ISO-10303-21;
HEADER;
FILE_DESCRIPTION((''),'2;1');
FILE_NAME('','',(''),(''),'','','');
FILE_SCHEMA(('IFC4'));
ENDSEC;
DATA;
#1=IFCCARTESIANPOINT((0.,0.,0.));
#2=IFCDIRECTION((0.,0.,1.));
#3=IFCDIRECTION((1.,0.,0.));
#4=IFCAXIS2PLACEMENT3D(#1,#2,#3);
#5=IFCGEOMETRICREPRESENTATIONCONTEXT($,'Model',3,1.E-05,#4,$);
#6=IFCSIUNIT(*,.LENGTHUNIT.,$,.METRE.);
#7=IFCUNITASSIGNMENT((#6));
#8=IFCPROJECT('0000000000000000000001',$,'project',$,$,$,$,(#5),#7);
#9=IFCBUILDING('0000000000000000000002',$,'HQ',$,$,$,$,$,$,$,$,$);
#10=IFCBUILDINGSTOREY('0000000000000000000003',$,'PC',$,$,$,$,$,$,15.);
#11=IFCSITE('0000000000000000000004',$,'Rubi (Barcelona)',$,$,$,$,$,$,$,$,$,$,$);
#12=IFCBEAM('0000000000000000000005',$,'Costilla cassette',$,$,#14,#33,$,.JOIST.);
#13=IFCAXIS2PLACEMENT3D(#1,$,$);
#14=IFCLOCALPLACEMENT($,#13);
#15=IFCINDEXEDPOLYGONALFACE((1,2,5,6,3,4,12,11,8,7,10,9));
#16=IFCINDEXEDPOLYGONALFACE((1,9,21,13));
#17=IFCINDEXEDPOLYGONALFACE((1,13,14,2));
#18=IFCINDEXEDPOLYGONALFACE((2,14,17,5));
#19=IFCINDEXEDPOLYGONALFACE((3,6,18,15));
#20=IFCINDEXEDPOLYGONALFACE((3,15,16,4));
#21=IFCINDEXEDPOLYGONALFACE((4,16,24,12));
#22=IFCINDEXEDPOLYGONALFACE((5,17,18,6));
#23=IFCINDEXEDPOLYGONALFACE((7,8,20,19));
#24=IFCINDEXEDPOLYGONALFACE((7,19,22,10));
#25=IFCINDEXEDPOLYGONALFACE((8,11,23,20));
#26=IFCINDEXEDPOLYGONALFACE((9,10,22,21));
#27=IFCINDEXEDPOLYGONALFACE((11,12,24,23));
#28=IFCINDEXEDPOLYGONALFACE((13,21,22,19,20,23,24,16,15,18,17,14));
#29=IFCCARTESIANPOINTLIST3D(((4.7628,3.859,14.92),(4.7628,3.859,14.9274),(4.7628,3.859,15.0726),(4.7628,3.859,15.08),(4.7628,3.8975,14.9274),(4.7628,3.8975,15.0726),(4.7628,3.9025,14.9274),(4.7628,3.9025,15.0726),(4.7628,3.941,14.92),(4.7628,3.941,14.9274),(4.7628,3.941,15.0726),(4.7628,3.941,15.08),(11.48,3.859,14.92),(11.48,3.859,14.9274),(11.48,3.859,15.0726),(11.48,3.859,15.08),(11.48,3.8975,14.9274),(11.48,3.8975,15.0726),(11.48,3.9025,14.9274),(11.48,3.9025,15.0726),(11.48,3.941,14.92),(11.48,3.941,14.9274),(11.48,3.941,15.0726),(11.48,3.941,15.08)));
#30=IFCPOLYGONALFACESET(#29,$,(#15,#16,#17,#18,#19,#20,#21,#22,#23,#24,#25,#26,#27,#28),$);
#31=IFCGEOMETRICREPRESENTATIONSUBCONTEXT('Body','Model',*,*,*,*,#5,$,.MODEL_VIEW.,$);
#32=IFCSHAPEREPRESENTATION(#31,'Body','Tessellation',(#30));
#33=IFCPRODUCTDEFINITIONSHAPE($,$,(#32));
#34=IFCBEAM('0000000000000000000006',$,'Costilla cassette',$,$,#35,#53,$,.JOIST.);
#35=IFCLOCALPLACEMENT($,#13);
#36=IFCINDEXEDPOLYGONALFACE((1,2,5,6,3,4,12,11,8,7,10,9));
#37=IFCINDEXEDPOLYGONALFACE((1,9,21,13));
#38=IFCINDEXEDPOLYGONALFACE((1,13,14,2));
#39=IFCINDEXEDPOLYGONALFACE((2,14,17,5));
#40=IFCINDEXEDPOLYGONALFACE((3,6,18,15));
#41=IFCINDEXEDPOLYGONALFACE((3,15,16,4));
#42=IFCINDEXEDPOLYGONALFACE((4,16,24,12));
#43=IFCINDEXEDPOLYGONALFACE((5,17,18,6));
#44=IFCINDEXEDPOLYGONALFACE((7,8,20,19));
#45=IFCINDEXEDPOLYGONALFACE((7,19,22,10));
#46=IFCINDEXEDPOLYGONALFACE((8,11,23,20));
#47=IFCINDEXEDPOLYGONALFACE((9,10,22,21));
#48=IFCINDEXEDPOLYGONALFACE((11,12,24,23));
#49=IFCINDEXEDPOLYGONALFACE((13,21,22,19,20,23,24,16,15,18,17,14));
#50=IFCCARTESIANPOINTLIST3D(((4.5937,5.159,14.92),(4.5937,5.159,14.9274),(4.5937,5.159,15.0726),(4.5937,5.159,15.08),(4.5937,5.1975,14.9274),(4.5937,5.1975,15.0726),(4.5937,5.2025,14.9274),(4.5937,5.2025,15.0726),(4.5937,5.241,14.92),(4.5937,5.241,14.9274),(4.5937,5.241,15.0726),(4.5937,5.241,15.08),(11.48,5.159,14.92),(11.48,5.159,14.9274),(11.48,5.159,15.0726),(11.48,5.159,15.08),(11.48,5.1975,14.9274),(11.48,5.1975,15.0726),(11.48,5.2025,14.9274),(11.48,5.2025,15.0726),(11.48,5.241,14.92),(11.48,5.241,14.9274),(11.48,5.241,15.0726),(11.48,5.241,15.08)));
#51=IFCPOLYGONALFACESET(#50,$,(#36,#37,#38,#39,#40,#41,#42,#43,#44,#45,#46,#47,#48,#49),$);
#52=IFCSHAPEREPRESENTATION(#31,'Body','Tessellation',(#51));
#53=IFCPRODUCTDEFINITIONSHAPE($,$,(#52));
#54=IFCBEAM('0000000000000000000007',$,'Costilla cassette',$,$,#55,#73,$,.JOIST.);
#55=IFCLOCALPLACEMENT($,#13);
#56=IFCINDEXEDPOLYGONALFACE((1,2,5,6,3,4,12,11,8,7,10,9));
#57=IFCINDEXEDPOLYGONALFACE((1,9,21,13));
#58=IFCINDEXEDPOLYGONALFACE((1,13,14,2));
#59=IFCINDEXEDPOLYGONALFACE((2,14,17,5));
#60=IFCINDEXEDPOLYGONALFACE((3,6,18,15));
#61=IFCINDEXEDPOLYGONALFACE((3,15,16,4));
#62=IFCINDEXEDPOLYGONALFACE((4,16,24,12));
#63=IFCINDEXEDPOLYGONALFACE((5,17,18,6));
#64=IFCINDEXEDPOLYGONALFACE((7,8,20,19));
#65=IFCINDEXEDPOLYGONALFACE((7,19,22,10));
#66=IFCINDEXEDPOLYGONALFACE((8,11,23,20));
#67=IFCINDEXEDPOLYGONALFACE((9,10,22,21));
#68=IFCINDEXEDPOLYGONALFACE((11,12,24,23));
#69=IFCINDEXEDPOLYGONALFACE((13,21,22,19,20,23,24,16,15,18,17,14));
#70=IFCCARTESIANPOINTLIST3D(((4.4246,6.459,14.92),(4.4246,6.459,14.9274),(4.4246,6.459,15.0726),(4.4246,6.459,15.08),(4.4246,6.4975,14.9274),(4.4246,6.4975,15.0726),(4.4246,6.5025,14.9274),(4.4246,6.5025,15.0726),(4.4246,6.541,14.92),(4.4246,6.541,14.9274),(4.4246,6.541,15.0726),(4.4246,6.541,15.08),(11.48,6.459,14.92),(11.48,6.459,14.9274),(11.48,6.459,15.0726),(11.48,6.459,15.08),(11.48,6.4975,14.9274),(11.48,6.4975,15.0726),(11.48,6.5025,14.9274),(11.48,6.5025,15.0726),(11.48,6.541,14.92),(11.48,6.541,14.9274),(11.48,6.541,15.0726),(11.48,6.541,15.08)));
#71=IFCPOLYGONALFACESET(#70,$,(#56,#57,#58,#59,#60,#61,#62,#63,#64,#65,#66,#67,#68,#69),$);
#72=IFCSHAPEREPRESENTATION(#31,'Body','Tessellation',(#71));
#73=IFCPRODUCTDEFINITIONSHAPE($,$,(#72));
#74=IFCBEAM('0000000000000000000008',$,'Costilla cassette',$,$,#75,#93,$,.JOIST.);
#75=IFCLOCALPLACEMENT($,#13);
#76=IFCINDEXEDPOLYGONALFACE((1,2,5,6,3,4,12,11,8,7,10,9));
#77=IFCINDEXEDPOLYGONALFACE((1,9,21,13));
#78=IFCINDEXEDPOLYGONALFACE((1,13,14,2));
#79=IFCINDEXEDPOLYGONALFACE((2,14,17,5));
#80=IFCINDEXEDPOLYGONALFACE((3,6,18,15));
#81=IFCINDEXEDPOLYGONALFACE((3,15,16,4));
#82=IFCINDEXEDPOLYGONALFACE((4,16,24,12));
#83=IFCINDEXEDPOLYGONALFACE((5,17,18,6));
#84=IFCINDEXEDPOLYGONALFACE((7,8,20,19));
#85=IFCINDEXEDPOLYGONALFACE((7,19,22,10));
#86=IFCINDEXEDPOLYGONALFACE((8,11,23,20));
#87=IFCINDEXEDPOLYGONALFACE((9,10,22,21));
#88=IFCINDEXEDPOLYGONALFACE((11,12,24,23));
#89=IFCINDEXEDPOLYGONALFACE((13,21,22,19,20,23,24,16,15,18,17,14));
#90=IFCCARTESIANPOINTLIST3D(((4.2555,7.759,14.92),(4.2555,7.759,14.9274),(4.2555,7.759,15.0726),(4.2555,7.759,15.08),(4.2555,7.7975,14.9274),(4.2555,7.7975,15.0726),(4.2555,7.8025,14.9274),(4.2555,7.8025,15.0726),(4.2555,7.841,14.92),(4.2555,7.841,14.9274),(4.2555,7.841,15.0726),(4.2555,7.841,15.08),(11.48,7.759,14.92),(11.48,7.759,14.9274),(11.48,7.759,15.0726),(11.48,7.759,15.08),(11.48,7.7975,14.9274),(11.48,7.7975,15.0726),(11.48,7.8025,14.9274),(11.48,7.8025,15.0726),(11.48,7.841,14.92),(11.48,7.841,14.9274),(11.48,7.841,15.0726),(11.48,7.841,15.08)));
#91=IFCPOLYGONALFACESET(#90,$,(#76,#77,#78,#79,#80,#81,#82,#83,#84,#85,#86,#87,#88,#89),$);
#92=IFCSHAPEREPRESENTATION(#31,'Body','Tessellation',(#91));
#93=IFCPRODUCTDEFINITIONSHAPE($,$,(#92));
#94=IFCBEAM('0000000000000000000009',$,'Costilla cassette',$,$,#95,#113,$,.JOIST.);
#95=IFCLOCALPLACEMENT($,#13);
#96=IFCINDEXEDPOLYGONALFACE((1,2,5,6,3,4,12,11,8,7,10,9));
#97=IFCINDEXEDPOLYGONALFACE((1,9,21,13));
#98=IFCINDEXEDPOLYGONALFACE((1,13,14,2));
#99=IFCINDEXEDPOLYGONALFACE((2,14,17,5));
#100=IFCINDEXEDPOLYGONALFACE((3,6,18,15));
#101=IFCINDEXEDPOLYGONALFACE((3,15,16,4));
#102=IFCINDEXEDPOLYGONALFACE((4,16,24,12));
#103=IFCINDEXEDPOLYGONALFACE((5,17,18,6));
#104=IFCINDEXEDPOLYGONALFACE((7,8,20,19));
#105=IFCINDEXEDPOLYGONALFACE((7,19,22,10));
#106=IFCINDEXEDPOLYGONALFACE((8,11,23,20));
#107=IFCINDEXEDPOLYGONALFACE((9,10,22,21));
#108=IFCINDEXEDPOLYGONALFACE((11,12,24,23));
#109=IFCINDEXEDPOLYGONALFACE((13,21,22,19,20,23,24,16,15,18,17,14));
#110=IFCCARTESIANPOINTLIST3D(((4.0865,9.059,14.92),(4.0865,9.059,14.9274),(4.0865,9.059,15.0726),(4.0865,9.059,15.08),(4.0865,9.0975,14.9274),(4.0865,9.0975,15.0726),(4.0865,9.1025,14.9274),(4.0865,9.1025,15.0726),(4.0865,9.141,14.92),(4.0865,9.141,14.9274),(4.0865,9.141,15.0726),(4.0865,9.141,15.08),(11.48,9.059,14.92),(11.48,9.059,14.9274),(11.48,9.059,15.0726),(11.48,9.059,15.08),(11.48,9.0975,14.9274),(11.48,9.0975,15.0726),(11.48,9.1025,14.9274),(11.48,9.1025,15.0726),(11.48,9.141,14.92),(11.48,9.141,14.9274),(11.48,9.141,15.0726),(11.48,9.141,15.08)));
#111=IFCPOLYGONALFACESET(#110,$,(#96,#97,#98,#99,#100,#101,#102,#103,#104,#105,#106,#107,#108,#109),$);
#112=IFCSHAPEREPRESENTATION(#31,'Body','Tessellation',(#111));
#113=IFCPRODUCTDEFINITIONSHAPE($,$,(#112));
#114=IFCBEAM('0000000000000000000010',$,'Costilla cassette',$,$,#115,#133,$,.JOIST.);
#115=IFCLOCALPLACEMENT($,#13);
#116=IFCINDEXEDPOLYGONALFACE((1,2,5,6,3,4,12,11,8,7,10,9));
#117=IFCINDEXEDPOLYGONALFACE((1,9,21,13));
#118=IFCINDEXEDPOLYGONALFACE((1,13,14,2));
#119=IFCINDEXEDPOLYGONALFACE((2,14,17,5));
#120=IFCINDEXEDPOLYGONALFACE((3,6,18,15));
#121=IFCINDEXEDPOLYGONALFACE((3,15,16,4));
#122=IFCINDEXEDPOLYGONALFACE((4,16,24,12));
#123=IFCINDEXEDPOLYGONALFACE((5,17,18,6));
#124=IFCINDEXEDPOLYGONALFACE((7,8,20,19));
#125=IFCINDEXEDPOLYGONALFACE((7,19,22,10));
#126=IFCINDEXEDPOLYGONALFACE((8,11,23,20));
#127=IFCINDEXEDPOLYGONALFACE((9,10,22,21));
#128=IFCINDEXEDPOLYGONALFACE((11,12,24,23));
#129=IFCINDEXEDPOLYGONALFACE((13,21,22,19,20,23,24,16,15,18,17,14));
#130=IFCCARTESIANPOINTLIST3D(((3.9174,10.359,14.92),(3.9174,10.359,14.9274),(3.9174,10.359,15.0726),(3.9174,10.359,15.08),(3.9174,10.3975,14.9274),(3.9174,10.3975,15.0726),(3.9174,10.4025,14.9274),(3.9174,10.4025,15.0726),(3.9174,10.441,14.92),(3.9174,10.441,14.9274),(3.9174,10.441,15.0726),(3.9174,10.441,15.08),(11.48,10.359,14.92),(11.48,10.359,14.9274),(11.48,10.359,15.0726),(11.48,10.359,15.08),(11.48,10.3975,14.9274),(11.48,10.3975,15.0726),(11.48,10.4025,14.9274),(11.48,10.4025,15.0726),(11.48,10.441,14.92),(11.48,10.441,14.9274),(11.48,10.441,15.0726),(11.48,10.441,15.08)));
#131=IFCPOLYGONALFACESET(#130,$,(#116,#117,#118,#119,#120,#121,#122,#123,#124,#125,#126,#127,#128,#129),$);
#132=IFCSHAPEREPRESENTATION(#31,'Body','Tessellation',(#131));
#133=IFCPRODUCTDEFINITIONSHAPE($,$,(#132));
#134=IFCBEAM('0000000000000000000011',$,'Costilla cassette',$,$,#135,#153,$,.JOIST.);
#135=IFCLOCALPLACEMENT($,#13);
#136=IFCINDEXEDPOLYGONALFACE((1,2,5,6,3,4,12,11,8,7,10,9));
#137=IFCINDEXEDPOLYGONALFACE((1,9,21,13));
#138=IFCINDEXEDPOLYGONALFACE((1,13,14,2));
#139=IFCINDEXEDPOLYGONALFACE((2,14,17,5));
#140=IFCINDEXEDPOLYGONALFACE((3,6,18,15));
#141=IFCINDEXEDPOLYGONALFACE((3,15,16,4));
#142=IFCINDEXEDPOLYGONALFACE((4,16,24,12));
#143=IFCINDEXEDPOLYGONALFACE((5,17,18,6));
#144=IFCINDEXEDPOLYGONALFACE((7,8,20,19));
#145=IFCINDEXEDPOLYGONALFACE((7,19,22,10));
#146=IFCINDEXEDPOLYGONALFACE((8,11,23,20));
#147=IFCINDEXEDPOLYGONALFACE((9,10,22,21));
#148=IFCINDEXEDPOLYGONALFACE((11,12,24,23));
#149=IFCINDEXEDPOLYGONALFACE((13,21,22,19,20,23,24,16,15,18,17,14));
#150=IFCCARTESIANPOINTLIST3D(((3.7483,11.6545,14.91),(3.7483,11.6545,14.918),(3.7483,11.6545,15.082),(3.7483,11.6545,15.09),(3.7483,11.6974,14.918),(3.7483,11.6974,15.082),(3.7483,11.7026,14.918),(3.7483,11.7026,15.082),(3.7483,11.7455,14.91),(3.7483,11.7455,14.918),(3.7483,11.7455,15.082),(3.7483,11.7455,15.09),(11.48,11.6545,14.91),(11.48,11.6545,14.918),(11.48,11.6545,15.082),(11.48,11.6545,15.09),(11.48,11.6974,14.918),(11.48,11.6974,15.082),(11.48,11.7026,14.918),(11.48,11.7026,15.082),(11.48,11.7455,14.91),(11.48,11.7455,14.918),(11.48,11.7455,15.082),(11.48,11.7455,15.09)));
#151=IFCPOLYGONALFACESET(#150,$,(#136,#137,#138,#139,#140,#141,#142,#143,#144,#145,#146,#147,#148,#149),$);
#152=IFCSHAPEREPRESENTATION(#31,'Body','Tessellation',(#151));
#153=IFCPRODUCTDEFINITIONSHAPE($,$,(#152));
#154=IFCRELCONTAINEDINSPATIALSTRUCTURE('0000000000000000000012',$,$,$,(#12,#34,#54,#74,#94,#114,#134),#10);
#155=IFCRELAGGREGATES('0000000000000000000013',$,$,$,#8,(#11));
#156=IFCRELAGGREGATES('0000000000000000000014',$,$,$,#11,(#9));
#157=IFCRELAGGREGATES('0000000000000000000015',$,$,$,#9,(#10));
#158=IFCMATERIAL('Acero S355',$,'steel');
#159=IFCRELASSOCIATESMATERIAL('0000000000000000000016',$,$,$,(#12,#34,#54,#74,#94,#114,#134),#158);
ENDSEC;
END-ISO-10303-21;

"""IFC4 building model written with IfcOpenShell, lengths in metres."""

from ifc_helpers import new_model, si_unit, frame, origin_with_axes, place, context, subcontext, project, spatial, i_section, extrude, material, element, save


model = new_model("IFC4")

# Units and contexts
model_context = context("Model", 3, precision=1e-05, world=origin_with_axes())
body_context = subcontext(model_context, "Body", "Model", "MODEL_VIEW")
ifc_project = project(units=[si_unit("LENGTHUNIT", "METRE")], contexts=[model_context])

# Site, building, storey
site = spatial("IfcSite", under=ifc_project, Name="Rubi (Barcelona)")
building = spatial("IfcBuilding", under=site, Name="HQ")
storey = spatial("IfcBuildingStorey", under=building, Name="PC", Elevation=15.0)

# Shared definitions
ifc_material = material(Name="Acero S355", Category="steel")

# Beams
beam_1_placement = place(None, origin_with_axes())
element("IfcBeam", 1, at=beam_1_placement, inside=storey, material=ifc_material, Name="Costilla cassette", PredefinedType="JOIST", context=body_context, shape_type="SweptSolid", body=[
    extrude(i_section(OverallWidth=0.082, OverallDepth=0.16, WebThickness=0.005, FlangeThickness=0.0074), frame((4.7628, 3.9, 15.0), z_axis=(1.0, 0.0, 0.0), x_axis=(0.0, 1.0, 0.0)), (0.0, 0.0, 1.0), 6.7172),
])
beam_2_placement = place(None, origin_with_axes())
element("IfcBeam", 2, at=beam_2_placement, inside=storey, material=ifc_material, Name="Costilla cassette", PredefinedType="JOIST", context=body_context, shape_type="SweptSolid", body=[
    extrude(i_section(OverallWidth=0.082, OverallDepth=0.16, WebThickness=0.005, FlangeThickness=0.0074), frame((4.5937, 5.2, 15.0), z_axis=(1.0, 0.0, 0.0), x_axis=(0.0, 1.0, 0.0)), (0.0, 0.0, 1.0), 6.8863),
])
beam_3_placement = place(None, origin_with_axes())
element("IfcBeam", 3, at=beam_3_placement, inside=storey, material=ifc_material, Name="Costilla cassette", PredefinedType="JOIST", context=body_context, shape_type="SweptSolid", body=[
    extrude(i_section(OverallWidth=0.082, OverallDepth=0.16, WebThickness=0.005, FlangeThickness=0.0074), frame((4.4246, 6.5, 15.0), z_axis=(1.0, 0.0, 0.0), x_axis=(0.0, 1.0, 0.0)), (0.0, 0.0, 1.0), 7.0554),
])
beam_4_placement = place(None, origin_with_axes())
element("IfcBeam", 4, at=beam_4_placement, inside=storey, material=ifc_material, Name="Costilla cassette", PredefinedType="JOIST", context=body_context, shape_type="SweptSolid", body=[
    extrude(i_section(OverallWidth=0.082, OverallDepth=0.16, WebThickness=0.005, FlangeThickness=0.0074), frame((4.2555, 7.8, 15.0), z_axis=(1.0, 0.0, 0.0), x_axis=(0.0, 1.0, 0.0)), (0.0, 0.0, 1.0), 7.2245),
])
beam_5_placement = place(None, origin_with_axes())
element("IfcBeam", 5, at=beam_5_placement, inside=storey, material=ifc_material, Name="Costilla cassette", PredefinedType="JOIST", context=body_context, shape_type="SweptSolid", body=[
    extrude(i_section(OverallWidth=0.082, OverallDepth=0.16, WebThickness=0.005, FlangeThickness=0.0074), frame((4.0865, 9.1, 15.0), z_axis=(1.0, 0.0, 0.0), x_axis=(0.0, 1.0, 0.0)), (0.0, 0.0, 1.0), 7.3935),
])
beam_6_placement = place(None, origin_with_axes())
element("IfcBeam", 6, at=beam_6_placement, inside=storey, material=ifc_material, Name="Costilla cassette", PredefinedType="JOIST", context=body_context, shape_type="SweptSolid", body=[
    extrude(i_section(OverallWidth=0.082, OverallDepth=0.16, WebThickness=0.005, FlangeThickness=0.0074), frame((3.9174, 10.4, 15.0), z_axis=(1.0, 0.0, 0.0), x_axis=(0.0, 1.0, 0.0)), (0.0, 0.0, 1.0), 7.5626),
])
beam_7_placement = place(None, origin_with_axes())
element("IfcBeam", 7, at=beam_7_placement, inside=storey, material=ifc_material, Name="Costilla cassette", PredefinedType="JOIST", context=body_context, shape_type="SweptSolid", body=[
    extrude(i_section(OverallWidth=0.091, OverallDepth=0.18, WebThickness=0.0053, FlangeThickness=0.008), frame((3.7483, 11.7, 15.0), z_axis=(1.0, 0.0, 0.0), x_axis=(0.0, 1.0, 0.0)), (0.0, 0.0, 1.0), 7.7317),
])

save(model, "model.ifc")
